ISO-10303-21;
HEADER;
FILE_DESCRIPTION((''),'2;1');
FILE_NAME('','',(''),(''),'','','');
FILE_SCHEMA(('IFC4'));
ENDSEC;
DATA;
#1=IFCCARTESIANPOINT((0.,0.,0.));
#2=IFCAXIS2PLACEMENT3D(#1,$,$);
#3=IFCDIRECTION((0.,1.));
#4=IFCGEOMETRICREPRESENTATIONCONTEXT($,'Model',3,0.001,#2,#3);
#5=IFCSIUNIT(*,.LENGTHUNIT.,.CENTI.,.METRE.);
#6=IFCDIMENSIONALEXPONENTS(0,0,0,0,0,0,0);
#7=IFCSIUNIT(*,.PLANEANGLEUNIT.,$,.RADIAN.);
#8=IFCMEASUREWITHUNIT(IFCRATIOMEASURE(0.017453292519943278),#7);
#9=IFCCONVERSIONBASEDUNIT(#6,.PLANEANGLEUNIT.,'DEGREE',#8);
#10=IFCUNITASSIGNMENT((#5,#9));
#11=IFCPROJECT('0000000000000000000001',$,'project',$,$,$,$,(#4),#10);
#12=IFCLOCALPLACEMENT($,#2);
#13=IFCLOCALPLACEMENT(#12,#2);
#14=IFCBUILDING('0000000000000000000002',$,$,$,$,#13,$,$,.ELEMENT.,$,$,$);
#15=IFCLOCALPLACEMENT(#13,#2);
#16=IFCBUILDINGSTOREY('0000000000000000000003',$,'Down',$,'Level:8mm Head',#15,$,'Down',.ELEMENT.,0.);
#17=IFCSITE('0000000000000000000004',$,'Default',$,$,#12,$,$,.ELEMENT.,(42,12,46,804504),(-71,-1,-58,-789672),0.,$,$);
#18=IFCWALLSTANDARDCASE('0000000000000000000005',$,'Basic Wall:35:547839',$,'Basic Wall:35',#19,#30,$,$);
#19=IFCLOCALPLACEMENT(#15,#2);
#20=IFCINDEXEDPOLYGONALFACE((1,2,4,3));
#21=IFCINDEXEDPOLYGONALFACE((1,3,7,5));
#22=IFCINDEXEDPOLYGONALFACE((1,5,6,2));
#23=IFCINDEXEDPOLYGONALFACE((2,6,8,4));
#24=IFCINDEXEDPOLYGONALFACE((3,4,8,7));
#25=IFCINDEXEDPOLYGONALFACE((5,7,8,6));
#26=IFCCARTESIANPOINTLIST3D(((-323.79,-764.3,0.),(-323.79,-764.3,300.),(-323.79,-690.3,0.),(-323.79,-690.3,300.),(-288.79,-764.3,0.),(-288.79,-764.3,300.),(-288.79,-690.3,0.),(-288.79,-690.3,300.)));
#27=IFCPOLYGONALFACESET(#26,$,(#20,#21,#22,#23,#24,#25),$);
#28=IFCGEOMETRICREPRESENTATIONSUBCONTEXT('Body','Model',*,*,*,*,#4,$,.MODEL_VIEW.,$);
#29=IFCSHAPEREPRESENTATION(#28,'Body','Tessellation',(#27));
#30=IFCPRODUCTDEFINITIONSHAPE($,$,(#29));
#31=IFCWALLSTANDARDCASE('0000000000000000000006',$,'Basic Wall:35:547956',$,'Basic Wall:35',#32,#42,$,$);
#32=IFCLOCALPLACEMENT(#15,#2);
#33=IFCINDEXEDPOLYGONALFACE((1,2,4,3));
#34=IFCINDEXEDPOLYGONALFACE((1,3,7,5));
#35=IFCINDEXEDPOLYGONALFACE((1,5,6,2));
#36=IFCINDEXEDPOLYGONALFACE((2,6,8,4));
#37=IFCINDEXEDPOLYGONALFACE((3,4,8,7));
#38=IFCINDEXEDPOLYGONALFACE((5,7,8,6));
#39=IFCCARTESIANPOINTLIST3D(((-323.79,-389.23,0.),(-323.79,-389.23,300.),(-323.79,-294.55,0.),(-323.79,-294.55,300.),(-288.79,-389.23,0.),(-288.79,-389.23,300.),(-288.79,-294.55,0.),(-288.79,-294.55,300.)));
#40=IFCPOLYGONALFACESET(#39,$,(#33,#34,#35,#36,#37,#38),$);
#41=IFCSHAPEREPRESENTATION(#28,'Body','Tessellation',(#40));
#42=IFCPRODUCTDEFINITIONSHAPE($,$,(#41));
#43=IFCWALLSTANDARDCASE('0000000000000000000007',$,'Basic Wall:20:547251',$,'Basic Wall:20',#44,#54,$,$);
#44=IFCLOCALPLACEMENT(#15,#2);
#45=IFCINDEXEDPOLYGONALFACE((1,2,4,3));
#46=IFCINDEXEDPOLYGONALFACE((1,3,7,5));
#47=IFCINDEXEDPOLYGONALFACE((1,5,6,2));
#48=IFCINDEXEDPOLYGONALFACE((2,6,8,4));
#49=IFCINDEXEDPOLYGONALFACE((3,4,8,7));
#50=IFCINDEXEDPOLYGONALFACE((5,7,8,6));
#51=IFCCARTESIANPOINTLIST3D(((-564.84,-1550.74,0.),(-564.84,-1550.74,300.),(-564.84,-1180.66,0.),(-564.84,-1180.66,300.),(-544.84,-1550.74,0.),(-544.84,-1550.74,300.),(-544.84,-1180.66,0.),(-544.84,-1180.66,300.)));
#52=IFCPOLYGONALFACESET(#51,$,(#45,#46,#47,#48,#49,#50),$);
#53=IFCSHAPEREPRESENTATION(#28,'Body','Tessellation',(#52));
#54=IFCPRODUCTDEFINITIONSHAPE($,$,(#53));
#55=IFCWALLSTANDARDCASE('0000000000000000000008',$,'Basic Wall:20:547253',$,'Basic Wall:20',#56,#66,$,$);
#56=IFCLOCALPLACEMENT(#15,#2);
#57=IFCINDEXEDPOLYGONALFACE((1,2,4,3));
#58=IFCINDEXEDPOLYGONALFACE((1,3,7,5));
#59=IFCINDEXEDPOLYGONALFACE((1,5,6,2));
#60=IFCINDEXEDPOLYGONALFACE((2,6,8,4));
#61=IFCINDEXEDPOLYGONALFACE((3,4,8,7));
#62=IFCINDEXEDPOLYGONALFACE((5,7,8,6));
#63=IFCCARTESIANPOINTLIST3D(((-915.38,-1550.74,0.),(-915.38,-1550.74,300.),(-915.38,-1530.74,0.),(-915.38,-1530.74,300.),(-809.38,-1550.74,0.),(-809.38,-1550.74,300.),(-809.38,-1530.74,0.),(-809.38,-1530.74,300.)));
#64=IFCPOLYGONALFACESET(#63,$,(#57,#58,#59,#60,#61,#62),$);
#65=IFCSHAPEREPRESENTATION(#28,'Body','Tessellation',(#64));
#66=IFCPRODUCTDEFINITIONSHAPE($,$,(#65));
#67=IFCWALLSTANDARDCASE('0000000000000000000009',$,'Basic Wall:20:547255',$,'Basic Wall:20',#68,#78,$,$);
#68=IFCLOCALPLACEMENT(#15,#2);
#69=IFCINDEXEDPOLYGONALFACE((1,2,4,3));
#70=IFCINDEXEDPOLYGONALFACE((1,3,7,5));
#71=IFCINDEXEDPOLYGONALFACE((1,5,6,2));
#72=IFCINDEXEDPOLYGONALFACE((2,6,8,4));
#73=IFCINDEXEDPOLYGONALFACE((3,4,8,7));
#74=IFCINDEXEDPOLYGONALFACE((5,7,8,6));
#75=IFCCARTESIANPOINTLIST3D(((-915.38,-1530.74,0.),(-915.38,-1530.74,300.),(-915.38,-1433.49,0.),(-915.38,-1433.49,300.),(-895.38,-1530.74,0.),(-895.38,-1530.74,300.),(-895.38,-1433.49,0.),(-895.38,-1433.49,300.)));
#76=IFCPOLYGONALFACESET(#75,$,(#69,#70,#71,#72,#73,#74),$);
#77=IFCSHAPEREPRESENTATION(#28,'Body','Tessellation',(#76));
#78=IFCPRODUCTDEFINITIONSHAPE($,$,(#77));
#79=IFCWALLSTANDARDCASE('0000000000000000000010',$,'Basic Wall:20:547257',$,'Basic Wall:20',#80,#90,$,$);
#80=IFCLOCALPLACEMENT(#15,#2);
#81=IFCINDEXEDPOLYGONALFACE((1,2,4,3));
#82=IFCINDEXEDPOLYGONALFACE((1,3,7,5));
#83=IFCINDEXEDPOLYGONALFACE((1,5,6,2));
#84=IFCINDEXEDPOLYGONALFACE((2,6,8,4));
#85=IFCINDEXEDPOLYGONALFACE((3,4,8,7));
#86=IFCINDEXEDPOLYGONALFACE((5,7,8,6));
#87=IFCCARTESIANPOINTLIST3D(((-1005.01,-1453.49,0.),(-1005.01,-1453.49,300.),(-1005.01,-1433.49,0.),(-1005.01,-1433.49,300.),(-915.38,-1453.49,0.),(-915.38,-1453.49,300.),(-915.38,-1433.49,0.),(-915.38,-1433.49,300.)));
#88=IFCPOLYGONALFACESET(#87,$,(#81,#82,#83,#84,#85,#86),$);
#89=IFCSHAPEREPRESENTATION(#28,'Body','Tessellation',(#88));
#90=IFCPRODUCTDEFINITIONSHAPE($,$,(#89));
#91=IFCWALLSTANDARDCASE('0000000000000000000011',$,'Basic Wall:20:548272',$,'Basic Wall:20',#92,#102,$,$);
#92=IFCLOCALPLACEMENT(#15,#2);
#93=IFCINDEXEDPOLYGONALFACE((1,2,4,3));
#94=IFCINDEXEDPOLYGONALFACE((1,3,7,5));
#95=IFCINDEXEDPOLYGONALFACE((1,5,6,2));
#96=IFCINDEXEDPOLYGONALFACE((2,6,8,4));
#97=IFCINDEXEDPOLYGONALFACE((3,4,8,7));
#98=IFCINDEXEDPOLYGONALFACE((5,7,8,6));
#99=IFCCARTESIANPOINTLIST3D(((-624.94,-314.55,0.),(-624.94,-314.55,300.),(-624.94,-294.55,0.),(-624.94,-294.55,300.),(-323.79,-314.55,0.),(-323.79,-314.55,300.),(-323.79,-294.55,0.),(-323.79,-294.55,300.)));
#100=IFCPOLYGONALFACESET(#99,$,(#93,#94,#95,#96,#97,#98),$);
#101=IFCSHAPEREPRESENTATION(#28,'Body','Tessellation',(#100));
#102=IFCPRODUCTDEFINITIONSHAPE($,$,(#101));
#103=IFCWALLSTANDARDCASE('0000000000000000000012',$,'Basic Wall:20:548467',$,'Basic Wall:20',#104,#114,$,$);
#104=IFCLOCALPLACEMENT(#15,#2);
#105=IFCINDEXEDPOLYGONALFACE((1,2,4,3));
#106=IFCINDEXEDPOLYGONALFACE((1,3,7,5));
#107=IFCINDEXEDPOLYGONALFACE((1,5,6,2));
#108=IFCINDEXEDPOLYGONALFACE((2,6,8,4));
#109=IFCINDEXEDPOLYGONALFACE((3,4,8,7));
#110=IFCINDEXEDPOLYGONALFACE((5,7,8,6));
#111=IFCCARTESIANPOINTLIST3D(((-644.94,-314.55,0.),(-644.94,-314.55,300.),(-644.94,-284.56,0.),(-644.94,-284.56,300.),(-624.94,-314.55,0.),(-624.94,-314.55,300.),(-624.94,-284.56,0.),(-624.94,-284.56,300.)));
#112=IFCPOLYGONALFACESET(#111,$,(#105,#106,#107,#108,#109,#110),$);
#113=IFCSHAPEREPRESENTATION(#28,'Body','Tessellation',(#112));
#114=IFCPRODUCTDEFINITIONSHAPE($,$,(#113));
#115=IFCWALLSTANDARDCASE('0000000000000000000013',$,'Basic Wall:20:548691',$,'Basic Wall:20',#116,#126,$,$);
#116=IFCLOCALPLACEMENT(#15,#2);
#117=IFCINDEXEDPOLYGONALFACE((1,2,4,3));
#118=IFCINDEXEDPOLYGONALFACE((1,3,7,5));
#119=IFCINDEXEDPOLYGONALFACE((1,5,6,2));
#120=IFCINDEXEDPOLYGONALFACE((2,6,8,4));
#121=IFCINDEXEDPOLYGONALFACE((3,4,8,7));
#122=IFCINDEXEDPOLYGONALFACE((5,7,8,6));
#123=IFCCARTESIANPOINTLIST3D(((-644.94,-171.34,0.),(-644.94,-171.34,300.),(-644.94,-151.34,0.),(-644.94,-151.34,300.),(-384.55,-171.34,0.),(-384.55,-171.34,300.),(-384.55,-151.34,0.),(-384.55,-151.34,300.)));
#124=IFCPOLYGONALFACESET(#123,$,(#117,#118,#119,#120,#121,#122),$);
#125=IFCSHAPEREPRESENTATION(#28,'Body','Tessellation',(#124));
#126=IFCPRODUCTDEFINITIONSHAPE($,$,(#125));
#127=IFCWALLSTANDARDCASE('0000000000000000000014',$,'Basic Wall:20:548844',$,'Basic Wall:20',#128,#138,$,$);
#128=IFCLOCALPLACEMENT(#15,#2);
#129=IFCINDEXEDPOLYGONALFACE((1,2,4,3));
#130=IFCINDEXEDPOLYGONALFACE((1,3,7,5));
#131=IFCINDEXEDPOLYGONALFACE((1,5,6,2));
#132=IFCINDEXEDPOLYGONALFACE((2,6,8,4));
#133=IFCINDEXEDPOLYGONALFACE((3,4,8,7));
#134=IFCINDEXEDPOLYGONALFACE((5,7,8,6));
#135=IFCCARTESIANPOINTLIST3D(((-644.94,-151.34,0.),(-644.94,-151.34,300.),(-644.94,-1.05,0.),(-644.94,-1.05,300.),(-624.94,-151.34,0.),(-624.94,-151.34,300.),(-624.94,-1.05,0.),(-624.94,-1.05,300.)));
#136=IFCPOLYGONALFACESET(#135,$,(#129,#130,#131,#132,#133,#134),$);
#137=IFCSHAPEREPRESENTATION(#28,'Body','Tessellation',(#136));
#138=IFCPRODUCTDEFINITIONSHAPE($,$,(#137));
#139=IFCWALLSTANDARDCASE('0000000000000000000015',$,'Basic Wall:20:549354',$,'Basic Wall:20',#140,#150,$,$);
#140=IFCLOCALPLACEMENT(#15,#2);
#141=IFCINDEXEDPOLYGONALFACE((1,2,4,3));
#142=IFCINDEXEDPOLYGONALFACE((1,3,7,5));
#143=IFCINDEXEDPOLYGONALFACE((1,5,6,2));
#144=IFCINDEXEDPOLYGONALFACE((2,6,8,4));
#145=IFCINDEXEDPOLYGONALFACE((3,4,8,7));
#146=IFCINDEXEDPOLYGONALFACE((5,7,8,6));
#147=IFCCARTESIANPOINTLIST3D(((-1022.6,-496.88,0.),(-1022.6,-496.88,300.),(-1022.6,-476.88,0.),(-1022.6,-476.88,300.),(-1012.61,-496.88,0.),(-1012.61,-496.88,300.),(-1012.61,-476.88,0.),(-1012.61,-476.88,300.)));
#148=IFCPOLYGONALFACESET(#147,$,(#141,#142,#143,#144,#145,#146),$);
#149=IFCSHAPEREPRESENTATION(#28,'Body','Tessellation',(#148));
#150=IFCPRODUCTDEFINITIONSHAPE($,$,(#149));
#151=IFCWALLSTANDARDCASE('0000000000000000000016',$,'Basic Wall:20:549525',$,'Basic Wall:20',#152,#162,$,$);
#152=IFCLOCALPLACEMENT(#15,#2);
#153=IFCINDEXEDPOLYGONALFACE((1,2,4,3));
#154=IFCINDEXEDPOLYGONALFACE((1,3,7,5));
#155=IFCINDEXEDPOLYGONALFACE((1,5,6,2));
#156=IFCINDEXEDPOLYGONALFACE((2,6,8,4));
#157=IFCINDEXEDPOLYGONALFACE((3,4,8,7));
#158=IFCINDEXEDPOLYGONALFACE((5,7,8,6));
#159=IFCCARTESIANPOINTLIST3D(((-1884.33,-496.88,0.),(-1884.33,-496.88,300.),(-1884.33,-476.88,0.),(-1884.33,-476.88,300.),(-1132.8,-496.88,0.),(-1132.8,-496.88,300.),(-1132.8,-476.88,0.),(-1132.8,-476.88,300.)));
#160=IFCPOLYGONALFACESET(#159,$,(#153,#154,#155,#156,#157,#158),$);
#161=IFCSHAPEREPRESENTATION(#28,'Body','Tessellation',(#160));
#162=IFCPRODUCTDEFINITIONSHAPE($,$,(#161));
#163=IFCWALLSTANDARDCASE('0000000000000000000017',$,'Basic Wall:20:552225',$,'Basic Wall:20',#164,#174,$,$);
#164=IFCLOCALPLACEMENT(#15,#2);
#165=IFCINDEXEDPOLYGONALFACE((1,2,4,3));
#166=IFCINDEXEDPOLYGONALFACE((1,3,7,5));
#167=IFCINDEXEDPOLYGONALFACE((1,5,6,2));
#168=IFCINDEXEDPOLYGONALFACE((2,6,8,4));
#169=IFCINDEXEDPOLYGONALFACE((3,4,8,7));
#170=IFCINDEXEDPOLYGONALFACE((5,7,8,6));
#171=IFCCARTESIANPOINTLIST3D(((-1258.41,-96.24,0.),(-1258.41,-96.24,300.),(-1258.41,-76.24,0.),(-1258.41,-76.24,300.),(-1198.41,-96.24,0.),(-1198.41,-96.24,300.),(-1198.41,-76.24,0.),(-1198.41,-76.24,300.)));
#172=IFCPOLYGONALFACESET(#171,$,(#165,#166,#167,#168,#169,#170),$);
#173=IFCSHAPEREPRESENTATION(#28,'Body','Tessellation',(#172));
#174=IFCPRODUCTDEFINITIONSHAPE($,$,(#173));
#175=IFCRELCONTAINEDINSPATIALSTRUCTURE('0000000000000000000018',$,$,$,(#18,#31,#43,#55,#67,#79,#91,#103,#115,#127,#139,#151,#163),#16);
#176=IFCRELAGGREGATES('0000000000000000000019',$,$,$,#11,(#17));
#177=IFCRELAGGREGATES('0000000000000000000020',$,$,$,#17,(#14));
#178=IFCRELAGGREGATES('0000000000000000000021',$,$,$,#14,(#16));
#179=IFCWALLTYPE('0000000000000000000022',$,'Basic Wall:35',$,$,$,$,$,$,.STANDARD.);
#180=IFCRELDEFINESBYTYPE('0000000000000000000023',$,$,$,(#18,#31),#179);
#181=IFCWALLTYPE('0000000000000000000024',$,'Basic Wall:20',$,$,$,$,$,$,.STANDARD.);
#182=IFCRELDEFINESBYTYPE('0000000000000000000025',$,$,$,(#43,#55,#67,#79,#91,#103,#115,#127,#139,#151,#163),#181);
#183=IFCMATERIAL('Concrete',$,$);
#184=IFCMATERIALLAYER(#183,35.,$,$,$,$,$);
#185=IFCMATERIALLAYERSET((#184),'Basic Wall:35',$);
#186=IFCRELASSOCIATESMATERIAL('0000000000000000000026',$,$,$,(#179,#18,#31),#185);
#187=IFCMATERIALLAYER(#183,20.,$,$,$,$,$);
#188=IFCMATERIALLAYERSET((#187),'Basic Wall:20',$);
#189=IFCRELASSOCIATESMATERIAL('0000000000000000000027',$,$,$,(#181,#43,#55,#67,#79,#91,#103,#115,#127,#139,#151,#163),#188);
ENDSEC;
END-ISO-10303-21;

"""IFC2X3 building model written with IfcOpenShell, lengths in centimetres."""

from ifc_helpers import new_model, entity, si_unit, converted_unit, direction, frame, frame_2d, origin, place, context, subcontext, project, spatial, rectangle, extrude, material, layer, layer_set, layer_usage, type_object, element, save


model = new_model("IFC2X3")

# Units and contexts
model_context = context("Model", 3, precision=0.001, world=origin(), true_north=direction((0.0, 1.0)))
body_context = subcontext(model_context, "Body", "Model", "MODEL_VIEW")
ifc_project = project(units=[si_unit("LENGTHUNIT", "METRE", prefix="CENTI"), converted_unit("PLANEANGLEUNIT", "DEGREE", entity("IfcRatioMeasure", 0.017453292519943278), si_unit("PLANEANGLEUNIT", "RADIAN"), dimensions=[0, 0, 0, 0, 0, 0, 0])], contexts=[model_context])

# Site, building, storey
site_placement = place(None, origin())
site = spatial("IfcSite", under=ifc_project, at=site_placement, Name="Default", CompositionType="ELEMENT", RefLatitude=(42, 12, 46, 804504), RefLongitude=(-71, -1, -58, -789672), RefElevation=0.0)
building_placement = place(site_placement, origin())
building = spatial("IfcBuilding", under=site, at=building_placement, CompositionType="ELEMENT")
storey_placement = place(building_placement, origin())
storey = spatial("IfcBuildingStorey", under=building, at=storey_placement, Name="Down", ObjectType="Level:8mm Head", LongName="Down", CompositionType="ELEMENT", Elevation=0.0)

# Walls
ifc_material = material(Name="Concrete")
ifc_layer_1 = layer(ifc_material, 35.0)
ifc_layer_set_1 = layer_set([ifc_layer_1], Name="Basic Wall:35")
ifc_layer_usage_1 = layer_usage(ifc_layer_set_1, "AXIS2", "POSITIVE", -17.5)
wall_type_1 = type_object("IfcWallType", Name="Basic Wall:35", PredefinedType="STANDARD", material=ifc_layer_set_1)
wall_1_placement = place(storey_placement, frame((-306.29, -764.3, 0.0), z_axis=(0.0, 0.0, 1.0), x_axis=(0.0, 1.0, 0.0)))
element("IfcWallStandardCase", 1, at=wall_1_placement, inside=storey, type_object=wall_type_1, material=ifc_layer_usage_1, Name="Basic Wall:35:547839", ObjectType="Basic Wall:35", context=body_context, shape_type="SweptSolid", body=[
    extrude(rectangle(XDim=74.0, YDim=35.0, at=frame_2d((37.0, 0.0), x_axis=(-1.0, 0.0))), origin(), (0.0, 0.0, 1.0), 300.0),
])
ifc_layer_usage_2 = layer_usage(ifc_layer_set_1, "AXIS2", "POSITIVE", -17.5)
wall_2_placement = place(storey_placement, frame((-306.29, -389.23, 0.0), z_axis=(0.0, 0.0, 1.0), x_axis=(0.0, 1.0, 0.0)))
element("IfcWallStandardCase", 2, at=wall_2_placement, inside=storey, type_object=wall_type_1, material=ifc_layer_usage_2, Name="Basic Wall:35:547956", ObjectType="Basic Wall:35", context=body_context, shape_type="SweptSolid", body=[
    extrude(rectangle(XDim=94.68, YDim=35.0, at=frame_2d((47.34, 0.0), x_axis=(-1.0, 0.0))), origin(), (0.0, 0.0, 1.0), 300.0),
])
ifc_layer_2 = layer(ifc_material, 20.0)
ifc_layer_set_2 = layer_set([ifc_layer_2], Name="Basic Wall:20")
ifc_layer_usage_3 = layer_usage(ifc_layer_set_2, "AXIS2", "POSITIVE", -10.0)
wall_type_2 = type_object("IfcWallType", Name="Basic Wall:20", PredefinedType="STANDARD", material=ifc_layer_set_2)
wall_3_placement = place(storey_placement, frame((-554.84, -1180.66, 0.0), z_axis=(0.0, 0.0, 1.0), x_axis=(0.0, -1.0, 0.0)))
element("IfcWallStandardCase", 3, at=wall_3_placement, inside=storey, type_object=wall_type_2, material=ifc_layer_usage_3, Name="Basic Wall:20:547251", ObjectType="Basic Wall:20", context=body_context, shape_type="SweptSolid", body=[
    extrude(rectangle(XDim=370.08, YDim=20.0, at=frame_2d((185.04, 0.0), x_axis=(-1.0, 0.0))), origin(), (0.0, 0.0, 1.0), 300.0),
])
ifc_layer_usage_4 = layer_usage(ifc_layer_set_2, "AXIS2", "NEGATIVE", 10.0)
wall_4_placement = place(storey_placement, frame((-809.38, -1540.74, 0.0), z_axis=(0.0, 0.0, 1.0), x_axis=(-1.0, 0.0, 0.0)))
element("IfcWallStandardCase", 4, at=wall_4_placement, inside=storey, type_object=wall_type_2, material=ifc_layer_usage_4, Name="Basic Wall:20:547253", ObjectType="Basic Wall:20", context=body_context, shape_type="SweptSolid", body=[
    extrude(rectangle(XDim=106.0, YDim=20.0, at=frame_2d((53.0, 0.0), x_axis=(-1.0, 0.0))), origin(), (0.0, 0.0, 1.0), 300.0),
])
ifc_layer_usage_5 = layer_usage(ifc_layer_set_2, "AXIS2", "NEGATIVE", 10.0)
wall_5_placement = place(storey_placement, frame((-905.38, -1530.74, 0.0), z_axis=(0.0, 0.0, 1.0), x_axis=(0.0, 1.0, 0.0)))
element("IfcWallStandardCase", 5, at=wall_5_placement, inside=storey, type_object=wall_type_2, material=ifc_layer_usage_5, Name="Basic Wall:20:547255", ObjectType="Basic Wall:20", context=body_context, shape_type="SweptSolid", body=[
    extrude(rectangle(XDim=97.25, YDim=20.0, at=frame_2d((48.63, 0.0), x_axis=(-1.0, 0.0))), origin(), (0.0, 0.0, 1.0), 300.0),
])
ifc_layer_usage_6 = layer_usage(ifc_layer_set_2, "AXIS2", "POSITIVE", -10.0)
wall_6_placement = place(storey_placement, frame((-915.38, -1443.49, 0.0), z_axis=(0.0, 0.0, 1.0), x_axis=(-1.0, 0.0, 0.0)))
element("IfcWallStandardCase", 6, at=wall_6_placement, inside=storey, type_object=wall_type_2, material=ifc_layer_usage_6, Name="Basic Wall:20:547257", ObjectType="Basic Wall:20", context=body_context, shape_type="SweptSolid", body=[
    extrude(rectangle(XDim=89.63, YDim=20.0, at=frame_2d((44.81, 0.0), x_axis=(-1.0, 0.0))), origin(), (0.0, 0.0, 1.0), 300.0),
])
ifc_layer_usage_7 = layer_usage(ifc_layer_set_2, "AXIS2", "POSITIVE", -10.0)
wall_7_placement = place(storey_placement, frame((-323.79, -304.55, 0.0), z_axis=(0.0, 0.0, 1.0), x_axis=(-1.0, 0.0, 0.0)))
element("IfcWallStandardCase", 7, at=wall_7_placement, inside=storey, type_object=wall_type_2, material=ifc_layer_usage_7, Name="Basic Wall:20:548272", ObjectType="Basic Wall:20", context=body_context, shape_type="SweptSolid", body=[
    extrude(rectangle(XDim=301.14, YDim=20.0, at=frame_2d((150.57, 0.0), x_axis=(-1.0, 0.0))), origin(), (0.0, 0.0, 1.0), 300.0),
])
ifc_layer_usage_8 = layer_usage(ifc_layer_set_2, "AXIS2", "NEGATIVE", 10.0)
wall_8_placement = place(storey_placement, frame((-634.94, -314.55, 0.0), z_axis=(0.0, 0.0, 1.0), x_axis=(0.0, 1.0, 0.0)))
element("IfcWallStandardCase", 8, at=wall_8_placement, inside=storey, type_object=wall_type_2, material=ifc_layer_usage_8, Name="Basic Wall:20:548467", ObjectType="Basic Wall:20", context=body_context, shape_type="SweptSolid", body=[
    extrude(rectangle(XDim=30.0, YDim=20.0, at=frame_2d((15.0, 0.0), x_axis=(-1.0, 0.0))), origin(), (0.0, 0.0, 1.0), 300.0),
])
ifc_layer_usage_9 = layer_usage(ifc_layer_set_2, "AXIS2", "NEGATIVE", 10.0)
wall_9_placement = place(storey_placement, frame((-384.55, -161.34, 0.0), z_axis=(0.0, 0.0, 1.0), x_axis=(-1.0, 0.0, 0.0)))
element("IfcWallStandardCase", 9, at=wall_9_placement, inside=storey, type_object=wall_type_2, material=ifc_layer_usage_9, Name="Basic Wall:20:548691", ObjectType="Basic Wall:20", context=body_context, shape_type="SweptSolid", body=[
    extrude(rectangle(XDim=260.39, YDim=20.0, at=frame_2d((130.19, 0.0), x_axis=(-1.0, 0.0))), origin(), (0.0, 0.0, 1.0), 300.0),
])
ifc_layer_usage_10 = layer_usage(ifc_layer_set_2, "AXIS2", "NEGATIVE", 10.0)
wall_10_placement = place(storey_placement, frame((-634.94, -151.34, 0.0), z_axis=(0.0, 0.0, 1.0), x_axis=(0.0, 1.0, 0.0)))
element("IfcWallStandardCase", 10, at=wall_10_placement, inside=storey, type_object=wall_type_2, material=ifc_layer_usage_10, Name="Basic Wall:20:548844", ObjectType="Basic Wall:20", context=body_context, shape_type="SweptSolid", body=[
    extrude(rectangle(XDim=150.29, YDim=20.0, at=frame_2d((75.15, 0.0), x_axis=(-1.0, 0.0))), origin(), (0.0, 0.0, 1.0), 300.0),
])
ifc_layer_usage_11 = layer_usage(ifc_layer_set_2, "AXIS2", "POSITIVE", -10.0)
wall_11_placement = place(storey_placement, frame((-1012.61, -486.88, 0.0), z_axis=(0.0, 0.0, 1.0), x_axis=(-1.0, 0.0, 0.0)))
element("IfcWallStandardCase", 11, at=wall_11_placement, inside=storey, type_object=wall_type_2, material=ifc_layer_usage_11, Name="Basic Wall:20:549354", ObjectType="Basic Wall:20", context=body_context, shape_type="SweptSolid", body=[
    extrude(rectangle(XDim=10.0, YDim=20.0, at=frame_2d((5.0, 0.0), x_axis=(-1.0, 0.0))), origin(), (0.0, 0.0, 1.0), 300.0),
])
ifc_layer_usage_12 = layer_usage(ifc_layer_set_2, "AXIS2", "POSITIVE", -10.0)
wall_12_placement = place(storey_placement, frame((-1132.8, -486.88, 0.0), z_axis=(0.0, 0.0, 1.0), x_axis=(-1.0, 0.0, 0.0)))
element("IfcWallStandardCase", 12, at=wall_12_placement, inside=storey, type_object=wall_type_2, material=ifc_layer_usage_12, Name="Basic Wall:20:549525", ObjectType="Basic Wall:20", context=body_context, shape_type="SweptSolid", body=[
    extrude(rectangle(XDim=751.53, YDim=20.0, at=frame_2d((375.76, 0.0), x_axis=(-1.0, 0.0))), origin(), (0.0, 0.0, 1.0), 300.0),
])
ifc_layer_usage_13 = layer_usage(ifc_layer_set_2, "AXIS2", "NEGATIVE", 10.0)
wall_13_placement = place(storey_placement, frame((-1198.41, -86.24, 0.0), z_axis=(0.0, 0.0, 1.0), x_axis=(-1.0, 0.0, 0.0)))
element("IfcWallStandardCase", 13, at=wall_13_placement, inside=storey, type_object=wall_type_2, material=ifc_layer_usage_13, Name="Basic Wall:20:552225", ObjectType="Basic Wall:20", context=body_context, shape_type="SweptSolid", body=[
    extrude(rectangle(XDim=60.0, YDim=20.0, at=frame_2d((30.0, 0.0), x_axis=(-1.0, 0.0))), origin(), (0.0, 0.0, 1.0), 300.0),
])

save(model, "model.ifc")
